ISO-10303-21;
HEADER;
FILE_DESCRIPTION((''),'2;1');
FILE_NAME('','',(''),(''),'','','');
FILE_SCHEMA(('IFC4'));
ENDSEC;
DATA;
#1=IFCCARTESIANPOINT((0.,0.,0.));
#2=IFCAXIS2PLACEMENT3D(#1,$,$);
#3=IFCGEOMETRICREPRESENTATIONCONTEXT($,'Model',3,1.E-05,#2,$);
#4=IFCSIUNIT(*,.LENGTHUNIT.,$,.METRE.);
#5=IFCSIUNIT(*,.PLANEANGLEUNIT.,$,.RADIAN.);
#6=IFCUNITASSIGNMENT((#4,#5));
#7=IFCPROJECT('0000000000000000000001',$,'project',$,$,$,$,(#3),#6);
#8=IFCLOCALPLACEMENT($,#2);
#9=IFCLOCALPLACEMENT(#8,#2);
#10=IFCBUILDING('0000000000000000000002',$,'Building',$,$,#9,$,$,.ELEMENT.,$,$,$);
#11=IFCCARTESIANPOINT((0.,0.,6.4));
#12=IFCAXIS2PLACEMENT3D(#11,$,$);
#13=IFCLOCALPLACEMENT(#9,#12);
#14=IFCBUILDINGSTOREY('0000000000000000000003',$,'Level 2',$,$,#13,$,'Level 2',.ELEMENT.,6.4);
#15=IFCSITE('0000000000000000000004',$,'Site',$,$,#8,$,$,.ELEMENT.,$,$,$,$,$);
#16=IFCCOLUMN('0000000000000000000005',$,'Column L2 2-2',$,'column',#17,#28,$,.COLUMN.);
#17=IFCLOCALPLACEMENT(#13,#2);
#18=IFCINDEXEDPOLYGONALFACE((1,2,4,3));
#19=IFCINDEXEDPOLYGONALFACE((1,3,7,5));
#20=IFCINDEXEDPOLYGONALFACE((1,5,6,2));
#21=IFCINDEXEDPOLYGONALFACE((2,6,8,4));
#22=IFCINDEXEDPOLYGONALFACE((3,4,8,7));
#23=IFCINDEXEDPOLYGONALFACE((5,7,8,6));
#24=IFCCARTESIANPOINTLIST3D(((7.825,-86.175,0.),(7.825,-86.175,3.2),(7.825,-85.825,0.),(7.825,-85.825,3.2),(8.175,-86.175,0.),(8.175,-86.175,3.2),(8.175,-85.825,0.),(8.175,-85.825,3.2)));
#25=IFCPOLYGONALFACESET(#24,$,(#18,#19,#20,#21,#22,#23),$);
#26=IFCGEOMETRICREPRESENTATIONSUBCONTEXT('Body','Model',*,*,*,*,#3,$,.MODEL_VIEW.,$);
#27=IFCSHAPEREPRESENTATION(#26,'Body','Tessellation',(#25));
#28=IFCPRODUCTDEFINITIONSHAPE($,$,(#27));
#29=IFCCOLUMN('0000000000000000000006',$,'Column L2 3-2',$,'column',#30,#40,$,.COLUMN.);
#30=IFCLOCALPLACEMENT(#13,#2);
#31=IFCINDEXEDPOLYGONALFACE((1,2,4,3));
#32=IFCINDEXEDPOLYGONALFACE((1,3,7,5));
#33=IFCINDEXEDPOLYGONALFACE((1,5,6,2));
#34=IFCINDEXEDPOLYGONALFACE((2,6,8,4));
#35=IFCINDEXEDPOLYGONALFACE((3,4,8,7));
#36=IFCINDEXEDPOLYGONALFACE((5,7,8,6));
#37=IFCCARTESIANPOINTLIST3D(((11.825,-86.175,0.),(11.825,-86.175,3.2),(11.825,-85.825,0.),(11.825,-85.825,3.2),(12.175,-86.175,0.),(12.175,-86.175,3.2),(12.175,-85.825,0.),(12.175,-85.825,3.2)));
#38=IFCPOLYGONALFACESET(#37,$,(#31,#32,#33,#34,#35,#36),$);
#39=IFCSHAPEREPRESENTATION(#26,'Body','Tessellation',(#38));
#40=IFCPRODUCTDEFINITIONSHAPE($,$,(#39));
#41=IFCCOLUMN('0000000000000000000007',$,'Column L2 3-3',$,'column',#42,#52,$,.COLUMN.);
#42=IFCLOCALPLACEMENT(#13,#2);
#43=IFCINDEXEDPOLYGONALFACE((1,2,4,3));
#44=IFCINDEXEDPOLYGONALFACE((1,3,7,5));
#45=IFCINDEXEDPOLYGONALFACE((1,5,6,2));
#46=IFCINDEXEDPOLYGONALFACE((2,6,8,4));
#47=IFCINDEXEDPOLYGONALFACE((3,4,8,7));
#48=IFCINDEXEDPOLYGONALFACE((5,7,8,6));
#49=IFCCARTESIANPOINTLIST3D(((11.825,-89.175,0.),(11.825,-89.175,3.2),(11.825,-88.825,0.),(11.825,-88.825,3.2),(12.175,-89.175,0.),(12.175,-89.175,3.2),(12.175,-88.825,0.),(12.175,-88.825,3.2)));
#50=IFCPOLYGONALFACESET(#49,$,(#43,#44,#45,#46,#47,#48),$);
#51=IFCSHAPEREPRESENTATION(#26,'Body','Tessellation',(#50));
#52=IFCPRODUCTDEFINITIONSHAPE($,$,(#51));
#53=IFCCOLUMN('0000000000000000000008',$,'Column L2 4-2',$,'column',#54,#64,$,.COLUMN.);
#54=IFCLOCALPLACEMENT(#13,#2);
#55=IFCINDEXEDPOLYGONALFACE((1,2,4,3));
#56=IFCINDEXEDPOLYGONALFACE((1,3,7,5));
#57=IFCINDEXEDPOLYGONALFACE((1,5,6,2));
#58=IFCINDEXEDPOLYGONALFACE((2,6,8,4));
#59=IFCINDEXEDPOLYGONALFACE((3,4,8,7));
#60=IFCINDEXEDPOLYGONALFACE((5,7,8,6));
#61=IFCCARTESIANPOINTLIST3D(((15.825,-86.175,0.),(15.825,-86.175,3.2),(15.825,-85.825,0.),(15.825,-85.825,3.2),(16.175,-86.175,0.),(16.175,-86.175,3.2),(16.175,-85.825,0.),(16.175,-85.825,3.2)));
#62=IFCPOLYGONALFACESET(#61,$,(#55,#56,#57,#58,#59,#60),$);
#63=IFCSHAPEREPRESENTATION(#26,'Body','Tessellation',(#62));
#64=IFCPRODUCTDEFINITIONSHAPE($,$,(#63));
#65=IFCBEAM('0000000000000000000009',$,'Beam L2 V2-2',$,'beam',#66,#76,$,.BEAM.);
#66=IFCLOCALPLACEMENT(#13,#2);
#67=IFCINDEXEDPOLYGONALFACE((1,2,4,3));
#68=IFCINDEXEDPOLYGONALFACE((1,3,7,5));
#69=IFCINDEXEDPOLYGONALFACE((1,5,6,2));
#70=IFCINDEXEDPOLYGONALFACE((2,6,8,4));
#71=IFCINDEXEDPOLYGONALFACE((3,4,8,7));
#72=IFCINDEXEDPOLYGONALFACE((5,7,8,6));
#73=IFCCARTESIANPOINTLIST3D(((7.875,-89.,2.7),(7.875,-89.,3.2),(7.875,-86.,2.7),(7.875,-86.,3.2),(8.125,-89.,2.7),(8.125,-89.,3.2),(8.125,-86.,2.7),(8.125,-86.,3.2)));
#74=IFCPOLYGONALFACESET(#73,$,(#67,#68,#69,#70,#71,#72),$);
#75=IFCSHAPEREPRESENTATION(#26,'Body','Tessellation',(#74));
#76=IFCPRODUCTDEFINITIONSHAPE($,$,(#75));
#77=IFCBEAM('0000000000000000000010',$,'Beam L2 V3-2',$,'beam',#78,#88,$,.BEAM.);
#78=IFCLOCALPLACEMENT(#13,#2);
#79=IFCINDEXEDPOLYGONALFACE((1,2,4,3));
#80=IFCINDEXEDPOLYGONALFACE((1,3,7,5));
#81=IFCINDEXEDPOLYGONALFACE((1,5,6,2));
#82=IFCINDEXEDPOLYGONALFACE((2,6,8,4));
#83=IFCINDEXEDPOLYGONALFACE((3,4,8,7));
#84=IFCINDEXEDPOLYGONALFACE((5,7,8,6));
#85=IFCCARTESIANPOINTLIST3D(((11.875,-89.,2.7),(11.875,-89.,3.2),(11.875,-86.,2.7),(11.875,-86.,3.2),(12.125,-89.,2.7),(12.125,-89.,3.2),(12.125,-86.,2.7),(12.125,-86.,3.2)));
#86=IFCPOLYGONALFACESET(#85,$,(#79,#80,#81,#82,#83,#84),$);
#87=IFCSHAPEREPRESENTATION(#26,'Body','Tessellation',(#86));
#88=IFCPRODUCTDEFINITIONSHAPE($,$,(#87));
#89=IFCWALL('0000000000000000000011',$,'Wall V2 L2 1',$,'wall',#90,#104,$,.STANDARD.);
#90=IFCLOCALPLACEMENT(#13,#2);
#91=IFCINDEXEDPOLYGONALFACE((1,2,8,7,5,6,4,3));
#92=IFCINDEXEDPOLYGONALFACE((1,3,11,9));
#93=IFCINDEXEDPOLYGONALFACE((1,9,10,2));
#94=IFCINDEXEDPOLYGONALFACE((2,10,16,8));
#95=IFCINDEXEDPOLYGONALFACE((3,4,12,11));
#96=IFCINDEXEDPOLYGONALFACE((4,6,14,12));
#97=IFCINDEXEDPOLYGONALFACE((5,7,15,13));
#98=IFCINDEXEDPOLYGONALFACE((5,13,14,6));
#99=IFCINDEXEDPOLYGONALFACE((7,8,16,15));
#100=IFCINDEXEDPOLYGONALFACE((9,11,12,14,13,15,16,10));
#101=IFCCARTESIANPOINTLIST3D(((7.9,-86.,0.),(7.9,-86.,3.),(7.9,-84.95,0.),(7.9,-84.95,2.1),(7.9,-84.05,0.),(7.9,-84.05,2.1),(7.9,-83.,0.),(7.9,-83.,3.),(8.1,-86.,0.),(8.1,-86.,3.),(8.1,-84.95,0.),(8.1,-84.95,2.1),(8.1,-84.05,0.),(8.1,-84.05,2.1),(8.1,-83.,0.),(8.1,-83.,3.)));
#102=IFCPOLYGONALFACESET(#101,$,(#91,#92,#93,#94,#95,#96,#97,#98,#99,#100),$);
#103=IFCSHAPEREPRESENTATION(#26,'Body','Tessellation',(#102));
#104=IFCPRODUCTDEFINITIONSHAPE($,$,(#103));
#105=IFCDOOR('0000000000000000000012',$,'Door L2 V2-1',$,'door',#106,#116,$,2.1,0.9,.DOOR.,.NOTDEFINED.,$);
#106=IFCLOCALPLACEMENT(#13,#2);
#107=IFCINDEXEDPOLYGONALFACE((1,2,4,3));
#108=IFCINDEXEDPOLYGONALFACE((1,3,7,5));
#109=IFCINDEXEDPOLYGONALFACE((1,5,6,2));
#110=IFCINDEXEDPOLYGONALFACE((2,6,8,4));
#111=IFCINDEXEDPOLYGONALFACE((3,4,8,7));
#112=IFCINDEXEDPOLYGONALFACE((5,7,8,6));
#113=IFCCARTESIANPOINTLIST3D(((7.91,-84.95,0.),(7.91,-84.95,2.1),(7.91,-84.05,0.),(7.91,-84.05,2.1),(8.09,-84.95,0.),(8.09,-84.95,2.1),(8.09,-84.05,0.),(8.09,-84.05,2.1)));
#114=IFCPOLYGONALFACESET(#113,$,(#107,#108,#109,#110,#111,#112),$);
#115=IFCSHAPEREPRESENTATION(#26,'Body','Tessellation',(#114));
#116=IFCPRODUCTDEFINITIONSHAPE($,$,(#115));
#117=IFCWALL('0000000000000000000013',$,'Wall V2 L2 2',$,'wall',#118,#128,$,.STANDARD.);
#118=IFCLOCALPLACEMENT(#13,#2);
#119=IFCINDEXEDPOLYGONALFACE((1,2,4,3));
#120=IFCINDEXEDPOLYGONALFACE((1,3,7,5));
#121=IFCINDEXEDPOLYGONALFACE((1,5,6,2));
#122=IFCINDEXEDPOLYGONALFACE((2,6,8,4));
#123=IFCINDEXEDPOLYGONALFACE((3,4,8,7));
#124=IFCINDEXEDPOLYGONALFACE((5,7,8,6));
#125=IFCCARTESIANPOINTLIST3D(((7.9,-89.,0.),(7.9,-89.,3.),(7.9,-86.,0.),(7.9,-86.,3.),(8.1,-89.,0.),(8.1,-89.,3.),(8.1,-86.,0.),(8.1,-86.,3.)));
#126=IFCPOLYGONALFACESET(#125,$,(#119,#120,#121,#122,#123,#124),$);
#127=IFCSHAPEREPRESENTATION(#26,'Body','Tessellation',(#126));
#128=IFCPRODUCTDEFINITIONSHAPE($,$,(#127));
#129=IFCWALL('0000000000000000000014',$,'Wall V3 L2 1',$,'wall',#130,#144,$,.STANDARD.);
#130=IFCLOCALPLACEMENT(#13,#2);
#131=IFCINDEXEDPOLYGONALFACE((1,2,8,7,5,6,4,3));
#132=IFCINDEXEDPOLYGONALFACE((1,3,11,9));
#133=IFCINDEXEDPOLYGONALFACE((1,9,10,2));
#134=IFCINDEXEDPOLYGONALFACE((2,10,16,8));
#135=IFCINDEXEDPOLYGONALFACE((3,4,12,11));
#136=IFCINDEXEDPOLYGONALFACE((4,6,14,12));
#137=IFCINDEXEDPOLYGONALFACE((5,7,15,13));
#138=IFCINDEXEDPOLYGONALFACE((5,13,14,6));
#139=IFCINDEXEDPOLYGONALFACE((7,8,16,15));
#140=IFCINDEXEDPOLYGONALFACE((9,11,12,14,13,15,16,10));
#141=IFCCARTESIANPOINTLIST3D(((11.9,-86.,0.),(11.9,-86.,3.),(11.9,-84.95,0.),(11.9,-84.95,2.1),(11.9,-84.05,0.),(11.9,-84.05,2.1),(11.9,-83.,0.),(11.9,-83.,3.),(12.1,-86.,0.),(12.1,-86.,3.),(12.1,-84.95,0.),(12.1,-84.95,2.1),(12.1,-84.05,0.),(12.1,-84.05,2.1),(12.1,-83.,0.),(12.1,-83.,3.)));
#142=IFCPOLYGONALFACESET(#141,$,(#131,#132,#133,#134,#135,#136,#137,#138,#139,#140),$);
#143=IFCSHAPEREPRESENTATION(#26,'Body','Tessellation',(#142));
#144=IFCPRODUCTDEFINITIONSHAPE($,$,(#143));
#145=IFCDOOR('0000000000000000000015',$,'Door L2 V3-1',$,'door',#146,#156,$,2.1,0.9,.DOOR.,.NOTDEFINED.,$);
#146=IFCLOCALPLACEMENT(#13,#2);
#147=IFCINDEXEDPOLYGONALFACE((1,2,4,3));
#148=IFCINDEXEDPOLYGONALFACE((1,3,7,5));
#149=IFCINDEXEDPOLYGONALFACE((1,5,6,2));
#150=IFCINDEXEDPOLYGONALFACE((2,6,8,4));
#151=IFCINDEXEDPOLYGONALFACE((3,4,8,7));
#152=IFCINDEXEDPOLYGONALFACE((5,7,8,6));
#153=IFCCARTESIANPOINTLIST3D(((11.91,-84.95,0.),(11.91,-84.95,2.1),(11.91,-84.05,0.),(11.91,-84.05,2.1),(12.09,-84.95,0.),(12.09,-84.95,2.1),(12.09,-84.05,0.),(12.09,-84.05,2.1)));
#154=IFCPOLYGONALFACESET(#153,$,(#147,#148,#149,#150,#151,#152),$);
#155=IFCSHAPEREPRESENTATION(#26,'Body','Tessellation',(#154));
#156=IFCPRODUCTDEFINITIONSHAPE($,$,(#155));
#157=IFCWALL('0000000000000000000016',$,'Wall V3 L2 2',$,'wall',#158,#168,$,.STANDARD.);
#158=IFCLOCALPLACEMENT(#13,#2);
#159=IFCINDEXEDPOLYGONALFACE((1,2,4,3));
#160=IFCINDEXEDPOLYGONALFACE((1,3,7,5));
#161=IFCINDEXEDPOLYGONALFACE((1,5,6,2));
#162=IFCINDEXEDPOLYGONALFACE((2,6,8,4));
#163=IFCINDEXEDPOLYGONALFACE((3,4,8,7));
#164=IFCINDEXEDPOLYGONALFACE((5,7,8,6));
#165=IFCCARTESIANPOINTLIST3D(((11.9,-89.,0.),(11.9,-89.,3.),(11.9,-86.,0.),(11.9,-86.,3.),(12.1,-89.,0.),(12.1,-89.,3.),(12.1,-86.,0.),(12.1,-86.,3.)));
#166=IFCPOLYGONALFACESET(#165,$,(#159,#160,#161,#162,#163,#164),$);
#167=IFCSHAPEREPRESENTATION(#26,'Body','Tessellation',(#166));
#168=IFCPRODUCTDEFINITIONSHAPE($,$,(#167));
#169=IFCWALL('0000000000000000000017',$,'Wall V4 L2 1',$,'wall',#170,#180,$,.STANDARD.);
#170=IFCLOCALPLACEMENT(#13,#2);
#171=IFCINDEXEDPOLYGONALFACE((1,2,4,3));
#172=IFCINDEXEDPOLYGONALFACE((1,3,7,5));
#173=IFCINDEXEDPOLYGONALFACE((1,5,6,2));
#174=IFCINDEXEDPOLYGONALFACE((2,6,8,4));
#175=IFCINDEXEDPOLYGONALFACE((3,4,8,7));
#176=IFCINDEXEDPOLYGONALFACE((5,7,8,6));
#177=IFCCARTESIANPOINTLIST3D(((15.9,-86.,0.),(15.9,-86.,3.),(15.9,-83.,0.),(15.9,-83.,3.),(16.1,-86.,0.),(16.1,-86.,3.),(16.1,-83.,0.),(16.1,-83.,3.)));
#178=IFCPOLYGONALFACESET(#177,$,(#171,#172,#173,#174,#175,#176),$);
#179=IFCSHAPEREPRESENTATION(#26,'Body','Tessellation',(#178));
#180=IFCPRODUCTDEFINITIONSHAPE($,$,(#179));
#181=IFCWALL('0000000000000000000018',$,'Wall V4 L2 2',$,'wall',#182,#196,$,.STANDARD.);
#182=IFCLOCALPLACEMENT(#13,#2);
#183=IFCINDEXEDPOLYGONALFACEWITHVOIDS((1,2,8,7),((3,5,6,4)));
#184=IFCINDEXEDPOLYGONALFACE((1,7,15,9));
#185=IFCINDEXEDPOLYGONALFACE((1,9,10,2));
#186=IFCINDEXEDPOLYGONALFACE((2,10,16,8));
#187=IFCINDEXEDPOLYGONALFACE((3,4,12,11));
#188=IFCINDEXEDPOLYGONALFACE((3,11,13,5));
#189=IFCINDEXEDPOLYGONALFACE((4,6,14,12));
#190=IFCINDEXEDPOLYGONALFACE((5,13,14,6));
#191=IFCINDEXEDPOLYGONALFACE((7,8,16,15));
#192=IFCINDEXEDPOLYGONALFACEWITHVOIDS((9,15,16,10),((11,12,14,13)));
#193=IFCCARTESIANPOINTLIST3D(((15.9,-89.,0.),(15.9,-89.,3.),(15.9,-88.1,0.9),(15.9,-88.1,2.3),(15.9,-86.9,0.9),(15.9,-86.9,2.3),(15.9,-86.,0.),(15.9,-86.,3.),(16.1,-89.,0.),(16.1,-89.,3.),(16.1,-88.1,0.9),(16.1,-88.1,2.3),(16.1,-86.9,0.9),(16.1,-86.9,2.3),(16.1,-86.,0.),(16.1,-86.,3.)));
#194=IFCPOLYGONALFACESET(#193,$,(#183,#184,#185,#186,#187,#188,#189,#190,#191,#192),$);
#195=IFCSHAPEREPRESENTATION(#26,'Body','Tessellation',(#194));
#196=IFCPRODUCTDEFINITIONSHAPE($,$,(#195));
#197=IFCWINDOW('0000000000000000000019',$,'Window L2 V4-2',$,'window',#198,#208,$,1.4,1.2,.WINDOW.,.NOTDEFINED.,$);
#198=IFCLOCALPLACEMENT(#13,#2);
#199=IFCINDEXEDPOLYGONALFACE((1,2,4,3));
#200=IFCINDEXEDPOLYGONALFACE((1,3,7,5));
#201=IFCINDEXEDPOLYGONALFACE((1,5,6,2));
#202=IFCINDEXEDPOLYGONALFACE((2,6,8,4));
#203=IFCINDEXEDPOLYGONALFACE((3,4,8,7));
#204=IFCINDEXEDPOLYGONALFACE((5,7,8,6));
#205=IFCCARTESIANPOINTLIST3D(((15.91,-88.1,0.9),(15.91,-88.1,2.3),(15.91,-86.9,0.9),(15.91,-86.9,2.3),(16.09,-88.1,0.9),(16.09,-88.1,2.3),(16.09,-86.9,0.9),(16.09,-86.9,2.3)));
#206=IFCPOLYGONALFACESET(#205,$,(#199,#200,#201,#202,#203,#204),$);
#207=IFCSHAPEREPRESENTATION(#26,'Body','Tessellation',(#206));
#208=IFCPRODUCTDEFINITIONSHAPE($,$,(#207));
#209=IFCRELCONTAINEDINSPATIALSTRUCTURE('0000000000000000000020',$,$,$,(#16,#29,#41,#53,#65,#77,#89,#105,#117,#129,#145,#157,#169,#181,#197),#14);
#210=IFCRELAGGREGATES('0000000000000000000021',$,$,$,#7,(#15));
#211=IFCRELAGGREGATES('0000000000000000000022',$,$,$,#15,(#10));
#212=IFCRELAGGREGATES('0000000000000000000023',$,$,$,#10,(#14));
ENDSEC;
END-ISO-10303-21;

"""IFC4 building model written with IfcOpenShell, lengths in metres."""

from ifc_helpers import new_model, si_unit, frame, frame_2d, origin, origin_2d, place, context, subcontext, project, spatial, rectangle, extrude, element, fill, save


model = new_model("IFC4")

# Units and contexts
model_context = context("Model", 3, precision=1e-05, world=origin())
body_context = subcontext(model_context, "Body", "Model", "MODEL_VIEW")
ifc_project = project(units=[si_unit("LENGTHUNIT", "METRE"), si_unit("PLANEANGLEUNIT", "RADIAN")], contexts=[model_context])

# Site, building, storey
site_placement = place(None, origin())
site = spatial("IfcSite", under=ifc_project, at=site_placement, Name="Site", CompositionType="ELEMENT")
building_placement = place(site_placement, origin())
building = spatial("IfcBuilding", under=site, at=building_placement, Name="Building", CompositionType="ELEMENT")
storey_placement = place(building_placement, frame((0.0, 0.0, 6.4)))
storey = spatial("IfcBuildingStorey", under=building, at=storey_placement, Name="Level 2", LongName="Level 2", CompositionType="ELEMENT", Elevation=6.4)

# Columns
for number, where, name in (
    (1, (8.0, -86.0, 0.0), "Column L2 2-2"),
    (2, (12.0, -86.0, 0.0), "Column L2 3-2"),
    (3, (12.0, -89.0, 0.0), "Column L2 3-3"),
    (4, (16.0, -86.0, 0.0), "Column L2 4-2"),
):
    element("IfcColumn", number, at=place(storey_placement, frame(where)), inside=storey, Name=name, ObjectType="column", PredefinedType="COLUMN", context=body_context, shape_type="SweptSolid", body=[
        extrude(rectangle(XDim=0.35, YDim=0.35, at=origin_2d()), origin(), (0.0, 0.0, 1.0), 3.2),
    ])

# Beams
for number, where, z_axis, x_axis, name in (
    (5, (8.0, -86.0, 2.95), (0.0, -1.0, 0.0), (0.0, 0.0, 1.0), "Beam L2 V2-2"),
    (6, (12.0, -86.0, 2.95), (0.0, -1.0, 0.0), (0.0, 0.0, 1.0), "Beam L2 V3-2"),
):
    element("IfcBeam", number, at=place(storey_placement, frame(where, z_axis=z_axis, x_axis=x_axis)), inside=storey, Name=name, ObjectType="beam", PredefinedType="BEAM", context=body_context, shape_type="SweptSolid", body=[
        extrude(rectangle(XDim=0.5, YDim=0.25, at=origin_2d()), origin(), (0.0, 0.0, 1.0), 3.0),
    ])

# Wall, opening, door
wall_1_placement = place(storey_placement, frame((8.0, -83.0, 0.0), z_axis=(0.0, 0.0, 1.0), x_axis=(0.0, -1.0, 0.0)))
wall_1 = element("IfcWall", 7, at=wall_1_placement, inside=storey, Name="Wall V2 L2 1", ObjectType="wall", PredefinedType="STANDARD", context=body_context, shape_type="SweptSolid", body=[
    extrude(rectangle(XDim=3.0, YDim=0.2, at=frame_2d((1.5, 0.0))), origin(), (0.0, 0.0, 1.0), 3.0),
])
opening_1_placement = place(storey_placement, frame((8.0, -84.5, 0.0), z_axis=(0.0, 0.0, 1.0), x_axis=(0.0, -1.0, 0.0)))
opening_1 = element("IfcOpeningElement", 8, at=opening_1_placement, cuts=wall_1, ObjectType="Opening", PredefinedType="OPENING", context=body_context, shape_type="SweptSolid", body=[
    extrude(rectangle(XDim=0.9, YDim=0.22, at=origin_2d()), origin(), (0.0, 0.0, 1.0), 2.1),
])
door_1_placement = place(storey_placement, frame((8.0, -84.5, 0.0), z_axis=(0.0, 0.0, 1.0), x_axis=(0.0, -1.0, 0.0)))
door_1 = element("IfcDoor", 9, at=door_1_placement, inside=storey, Name="Door L2 V2-1", ObjectType="door", OperationType="NOTDEFINED", OverallHeight=2.1, OverallWidth=0.9, PredefinedType="DOOR", context=body_context, shape_type="SweptSolid", body=[
    extrude(rectangle(XDim=0.9, YDim=0.18, at=origin_2d()), origin(), (0.0, 0.0, 1.0), 2.1),
])
fill(opening_1, door_1)

# Wall
wall_2_placement = place(storey_placement, frame((8.0, -86.0, 0.0), z_axis=(0.0, 0.0, 1.0), x_axis=(0.0, -1.0, 0.0)))
element("IfcWall", 10, at=wall_2_placement, inside=storey, Name="Wall V2 L2 2", ObjectType="wall", PredefinedType="STANDARD", context=body_context, shape_type="SweptSolid", body=[
    extrude(rectangle(XDim=3.0, YDim=0.2, at=frame_2d((1.5, 0.0))), origin(), (0.0, 0.0, 1.0), 3.0),
])

# Wall, opening, door
wall_3_placement = place(storey_placement, frame((12.0, -83.0, 0.0), z_axis=(0.0, 0.0, 1.0), x_axis=(0.0, -1.0, 0.0)))
wall_3 = element("IfcWall", 11, at=wall_3_placement, inside=storey, Name="Wall V3 L2 1", ObjectType="wall", PredefinedType="STANDARD", context=body_context, shape_type="SweptSolid", body=[
    extrude(rectangle(XDim=3.0, YDim=0.2, at=frame_2d((1.5, 0.0))), origin(), (0.0, 0.0, 1.0), 3.0),
])
opening_2_placement = place(storey_placement, frame((12.0, -84.5, 0.0), z_axis=(0.0, 0.0, 1.0), x_axis=(0.0, -1.0, 0.0)))
opening_2 = element("IfcOpeningElement", 12, at=opening_2_placement, cuts=wall_3, ObjectType="Opening", PredefinedType="OPENING", context=body_context, shape_type="SweptSolid", body=[
    extrude(rectangle(XDim=0.9, YDim=0.22, at=origin_2d()), origin(), (0.0, 0.0, 1.0), 2.1),
])
door_2_placement = place(storey_placement, frame((12.0, -84.5, 0.0), z_axis=(0.0, 0.0, 1.0), x_axis=(0.0, -1.0, 0.0)))
door_2 = element("IfcDoor", 13, at=door_2_placement, inside=storey, Name="Door L2 V3-1", ObjectType="door", OperationType="NOTDEFINED", OverallHeight=2.1, OverallWidth=0.9, PredefinedType="DOOR", context=body_context, shape_type="SweptSolid", body=[
    extrude(rectangle(XDim=0.9, YDim=0.18, at=origin_2d()), origin(), (0.0, 0.0, 1.0), 2.1),
])
fill(opening_2, door_2)

# Walls
for number, where, z_axis, x_axis, name in (
    (14, (12.0, -86.0, 0.0), (0.0, 0.0, 1.0), (0.0, -1.0, 0.0), "Wall V3 L2 2"),
    (15, (16.0, -83.0, 0.0), (0.0, 0.0, 1.0), (0.0, -1.0, 0.0), "Wall V4 L2 1"),
):
    element("IfcWall", number, at=place(storey_placement, frame(where, z_axis=z_axis, x_axis=x_axis)), inside=storey, Name=name, ObjectType="wall", PredefinedType="STANDARD", context=body_context, shape_type="SweptSolid", body=[
        extrude(rectangle(XDim=3.0, YDim=0.2, at=frame_2d((1.5, 0.0))), origin(), (0.0, 0.0, 1.0), 3.0),
    ])

# Wall, opening, window
wall_4_placement = place(storey_placement, frame((16.0, -86.0, 0.0), z_axis=(0.0, 0.0, 1.0), x_axis=(0.0, -1.0, 0.0)))
wall_4 = element("IfcWall", 16, at=wall_4_placement, inside=storey, Name="Wall V4 L2 2", ObjectType="wall", PredefinedType="STANDARD", context=body_context, shape_type="SweptSolid", body=[
    extrude(rectangle(XDim=3.0, YDim=0.2, at=frame_2d((1.5, 0.0))), origin(), (0.0, 0.0, 1.0), 3.0),
])
opening_3_placement = place(storey_placement, frame((16.0, -87.5, 0.9), z_axis=(0.0, 0.0, 1.0), x_axis=(0.0, -1.0, 0.0)))
opening_3 = element("IfcOpeningElement", 17, at=opening_3_placement, cuts=wall_4, ObjectType="Opening", PredefinedType="OPENING", context=body_context, shape_type="SweptSolid", body=[
    extrude(rectangle(XDim=1.2, YDim=0.22, at=origin_2d()), origin(), (0.0, 0.0, 1.0), 1.4),
])
window_1_placement = place(storey_placement, frame((16.0, -87.5, 0.9), z_axis=(0.0, 0.0, 1.0), x_axis=(0.0, -1.0, 0.0)))
window_1 = element("IfcWindow", 18, at=window_1_placement, inside=storey, Name="Window L2 V4-2", ObjectType="window", OverallHeight=1.4, OverallWidth=1.2, PartitioningType="NOTDEFINED", PredefinedType="WINDOW", context=body_context, shape_type="SweptSolid", body=[
    extrude(rectangle(XDim=1.2, YDim=0.18, at=origin_2d()), origin(), (0.0, 0.0, 1.0), 1.4),
])
fill(opening_3, window_1)

save(model, "model.ifc")
